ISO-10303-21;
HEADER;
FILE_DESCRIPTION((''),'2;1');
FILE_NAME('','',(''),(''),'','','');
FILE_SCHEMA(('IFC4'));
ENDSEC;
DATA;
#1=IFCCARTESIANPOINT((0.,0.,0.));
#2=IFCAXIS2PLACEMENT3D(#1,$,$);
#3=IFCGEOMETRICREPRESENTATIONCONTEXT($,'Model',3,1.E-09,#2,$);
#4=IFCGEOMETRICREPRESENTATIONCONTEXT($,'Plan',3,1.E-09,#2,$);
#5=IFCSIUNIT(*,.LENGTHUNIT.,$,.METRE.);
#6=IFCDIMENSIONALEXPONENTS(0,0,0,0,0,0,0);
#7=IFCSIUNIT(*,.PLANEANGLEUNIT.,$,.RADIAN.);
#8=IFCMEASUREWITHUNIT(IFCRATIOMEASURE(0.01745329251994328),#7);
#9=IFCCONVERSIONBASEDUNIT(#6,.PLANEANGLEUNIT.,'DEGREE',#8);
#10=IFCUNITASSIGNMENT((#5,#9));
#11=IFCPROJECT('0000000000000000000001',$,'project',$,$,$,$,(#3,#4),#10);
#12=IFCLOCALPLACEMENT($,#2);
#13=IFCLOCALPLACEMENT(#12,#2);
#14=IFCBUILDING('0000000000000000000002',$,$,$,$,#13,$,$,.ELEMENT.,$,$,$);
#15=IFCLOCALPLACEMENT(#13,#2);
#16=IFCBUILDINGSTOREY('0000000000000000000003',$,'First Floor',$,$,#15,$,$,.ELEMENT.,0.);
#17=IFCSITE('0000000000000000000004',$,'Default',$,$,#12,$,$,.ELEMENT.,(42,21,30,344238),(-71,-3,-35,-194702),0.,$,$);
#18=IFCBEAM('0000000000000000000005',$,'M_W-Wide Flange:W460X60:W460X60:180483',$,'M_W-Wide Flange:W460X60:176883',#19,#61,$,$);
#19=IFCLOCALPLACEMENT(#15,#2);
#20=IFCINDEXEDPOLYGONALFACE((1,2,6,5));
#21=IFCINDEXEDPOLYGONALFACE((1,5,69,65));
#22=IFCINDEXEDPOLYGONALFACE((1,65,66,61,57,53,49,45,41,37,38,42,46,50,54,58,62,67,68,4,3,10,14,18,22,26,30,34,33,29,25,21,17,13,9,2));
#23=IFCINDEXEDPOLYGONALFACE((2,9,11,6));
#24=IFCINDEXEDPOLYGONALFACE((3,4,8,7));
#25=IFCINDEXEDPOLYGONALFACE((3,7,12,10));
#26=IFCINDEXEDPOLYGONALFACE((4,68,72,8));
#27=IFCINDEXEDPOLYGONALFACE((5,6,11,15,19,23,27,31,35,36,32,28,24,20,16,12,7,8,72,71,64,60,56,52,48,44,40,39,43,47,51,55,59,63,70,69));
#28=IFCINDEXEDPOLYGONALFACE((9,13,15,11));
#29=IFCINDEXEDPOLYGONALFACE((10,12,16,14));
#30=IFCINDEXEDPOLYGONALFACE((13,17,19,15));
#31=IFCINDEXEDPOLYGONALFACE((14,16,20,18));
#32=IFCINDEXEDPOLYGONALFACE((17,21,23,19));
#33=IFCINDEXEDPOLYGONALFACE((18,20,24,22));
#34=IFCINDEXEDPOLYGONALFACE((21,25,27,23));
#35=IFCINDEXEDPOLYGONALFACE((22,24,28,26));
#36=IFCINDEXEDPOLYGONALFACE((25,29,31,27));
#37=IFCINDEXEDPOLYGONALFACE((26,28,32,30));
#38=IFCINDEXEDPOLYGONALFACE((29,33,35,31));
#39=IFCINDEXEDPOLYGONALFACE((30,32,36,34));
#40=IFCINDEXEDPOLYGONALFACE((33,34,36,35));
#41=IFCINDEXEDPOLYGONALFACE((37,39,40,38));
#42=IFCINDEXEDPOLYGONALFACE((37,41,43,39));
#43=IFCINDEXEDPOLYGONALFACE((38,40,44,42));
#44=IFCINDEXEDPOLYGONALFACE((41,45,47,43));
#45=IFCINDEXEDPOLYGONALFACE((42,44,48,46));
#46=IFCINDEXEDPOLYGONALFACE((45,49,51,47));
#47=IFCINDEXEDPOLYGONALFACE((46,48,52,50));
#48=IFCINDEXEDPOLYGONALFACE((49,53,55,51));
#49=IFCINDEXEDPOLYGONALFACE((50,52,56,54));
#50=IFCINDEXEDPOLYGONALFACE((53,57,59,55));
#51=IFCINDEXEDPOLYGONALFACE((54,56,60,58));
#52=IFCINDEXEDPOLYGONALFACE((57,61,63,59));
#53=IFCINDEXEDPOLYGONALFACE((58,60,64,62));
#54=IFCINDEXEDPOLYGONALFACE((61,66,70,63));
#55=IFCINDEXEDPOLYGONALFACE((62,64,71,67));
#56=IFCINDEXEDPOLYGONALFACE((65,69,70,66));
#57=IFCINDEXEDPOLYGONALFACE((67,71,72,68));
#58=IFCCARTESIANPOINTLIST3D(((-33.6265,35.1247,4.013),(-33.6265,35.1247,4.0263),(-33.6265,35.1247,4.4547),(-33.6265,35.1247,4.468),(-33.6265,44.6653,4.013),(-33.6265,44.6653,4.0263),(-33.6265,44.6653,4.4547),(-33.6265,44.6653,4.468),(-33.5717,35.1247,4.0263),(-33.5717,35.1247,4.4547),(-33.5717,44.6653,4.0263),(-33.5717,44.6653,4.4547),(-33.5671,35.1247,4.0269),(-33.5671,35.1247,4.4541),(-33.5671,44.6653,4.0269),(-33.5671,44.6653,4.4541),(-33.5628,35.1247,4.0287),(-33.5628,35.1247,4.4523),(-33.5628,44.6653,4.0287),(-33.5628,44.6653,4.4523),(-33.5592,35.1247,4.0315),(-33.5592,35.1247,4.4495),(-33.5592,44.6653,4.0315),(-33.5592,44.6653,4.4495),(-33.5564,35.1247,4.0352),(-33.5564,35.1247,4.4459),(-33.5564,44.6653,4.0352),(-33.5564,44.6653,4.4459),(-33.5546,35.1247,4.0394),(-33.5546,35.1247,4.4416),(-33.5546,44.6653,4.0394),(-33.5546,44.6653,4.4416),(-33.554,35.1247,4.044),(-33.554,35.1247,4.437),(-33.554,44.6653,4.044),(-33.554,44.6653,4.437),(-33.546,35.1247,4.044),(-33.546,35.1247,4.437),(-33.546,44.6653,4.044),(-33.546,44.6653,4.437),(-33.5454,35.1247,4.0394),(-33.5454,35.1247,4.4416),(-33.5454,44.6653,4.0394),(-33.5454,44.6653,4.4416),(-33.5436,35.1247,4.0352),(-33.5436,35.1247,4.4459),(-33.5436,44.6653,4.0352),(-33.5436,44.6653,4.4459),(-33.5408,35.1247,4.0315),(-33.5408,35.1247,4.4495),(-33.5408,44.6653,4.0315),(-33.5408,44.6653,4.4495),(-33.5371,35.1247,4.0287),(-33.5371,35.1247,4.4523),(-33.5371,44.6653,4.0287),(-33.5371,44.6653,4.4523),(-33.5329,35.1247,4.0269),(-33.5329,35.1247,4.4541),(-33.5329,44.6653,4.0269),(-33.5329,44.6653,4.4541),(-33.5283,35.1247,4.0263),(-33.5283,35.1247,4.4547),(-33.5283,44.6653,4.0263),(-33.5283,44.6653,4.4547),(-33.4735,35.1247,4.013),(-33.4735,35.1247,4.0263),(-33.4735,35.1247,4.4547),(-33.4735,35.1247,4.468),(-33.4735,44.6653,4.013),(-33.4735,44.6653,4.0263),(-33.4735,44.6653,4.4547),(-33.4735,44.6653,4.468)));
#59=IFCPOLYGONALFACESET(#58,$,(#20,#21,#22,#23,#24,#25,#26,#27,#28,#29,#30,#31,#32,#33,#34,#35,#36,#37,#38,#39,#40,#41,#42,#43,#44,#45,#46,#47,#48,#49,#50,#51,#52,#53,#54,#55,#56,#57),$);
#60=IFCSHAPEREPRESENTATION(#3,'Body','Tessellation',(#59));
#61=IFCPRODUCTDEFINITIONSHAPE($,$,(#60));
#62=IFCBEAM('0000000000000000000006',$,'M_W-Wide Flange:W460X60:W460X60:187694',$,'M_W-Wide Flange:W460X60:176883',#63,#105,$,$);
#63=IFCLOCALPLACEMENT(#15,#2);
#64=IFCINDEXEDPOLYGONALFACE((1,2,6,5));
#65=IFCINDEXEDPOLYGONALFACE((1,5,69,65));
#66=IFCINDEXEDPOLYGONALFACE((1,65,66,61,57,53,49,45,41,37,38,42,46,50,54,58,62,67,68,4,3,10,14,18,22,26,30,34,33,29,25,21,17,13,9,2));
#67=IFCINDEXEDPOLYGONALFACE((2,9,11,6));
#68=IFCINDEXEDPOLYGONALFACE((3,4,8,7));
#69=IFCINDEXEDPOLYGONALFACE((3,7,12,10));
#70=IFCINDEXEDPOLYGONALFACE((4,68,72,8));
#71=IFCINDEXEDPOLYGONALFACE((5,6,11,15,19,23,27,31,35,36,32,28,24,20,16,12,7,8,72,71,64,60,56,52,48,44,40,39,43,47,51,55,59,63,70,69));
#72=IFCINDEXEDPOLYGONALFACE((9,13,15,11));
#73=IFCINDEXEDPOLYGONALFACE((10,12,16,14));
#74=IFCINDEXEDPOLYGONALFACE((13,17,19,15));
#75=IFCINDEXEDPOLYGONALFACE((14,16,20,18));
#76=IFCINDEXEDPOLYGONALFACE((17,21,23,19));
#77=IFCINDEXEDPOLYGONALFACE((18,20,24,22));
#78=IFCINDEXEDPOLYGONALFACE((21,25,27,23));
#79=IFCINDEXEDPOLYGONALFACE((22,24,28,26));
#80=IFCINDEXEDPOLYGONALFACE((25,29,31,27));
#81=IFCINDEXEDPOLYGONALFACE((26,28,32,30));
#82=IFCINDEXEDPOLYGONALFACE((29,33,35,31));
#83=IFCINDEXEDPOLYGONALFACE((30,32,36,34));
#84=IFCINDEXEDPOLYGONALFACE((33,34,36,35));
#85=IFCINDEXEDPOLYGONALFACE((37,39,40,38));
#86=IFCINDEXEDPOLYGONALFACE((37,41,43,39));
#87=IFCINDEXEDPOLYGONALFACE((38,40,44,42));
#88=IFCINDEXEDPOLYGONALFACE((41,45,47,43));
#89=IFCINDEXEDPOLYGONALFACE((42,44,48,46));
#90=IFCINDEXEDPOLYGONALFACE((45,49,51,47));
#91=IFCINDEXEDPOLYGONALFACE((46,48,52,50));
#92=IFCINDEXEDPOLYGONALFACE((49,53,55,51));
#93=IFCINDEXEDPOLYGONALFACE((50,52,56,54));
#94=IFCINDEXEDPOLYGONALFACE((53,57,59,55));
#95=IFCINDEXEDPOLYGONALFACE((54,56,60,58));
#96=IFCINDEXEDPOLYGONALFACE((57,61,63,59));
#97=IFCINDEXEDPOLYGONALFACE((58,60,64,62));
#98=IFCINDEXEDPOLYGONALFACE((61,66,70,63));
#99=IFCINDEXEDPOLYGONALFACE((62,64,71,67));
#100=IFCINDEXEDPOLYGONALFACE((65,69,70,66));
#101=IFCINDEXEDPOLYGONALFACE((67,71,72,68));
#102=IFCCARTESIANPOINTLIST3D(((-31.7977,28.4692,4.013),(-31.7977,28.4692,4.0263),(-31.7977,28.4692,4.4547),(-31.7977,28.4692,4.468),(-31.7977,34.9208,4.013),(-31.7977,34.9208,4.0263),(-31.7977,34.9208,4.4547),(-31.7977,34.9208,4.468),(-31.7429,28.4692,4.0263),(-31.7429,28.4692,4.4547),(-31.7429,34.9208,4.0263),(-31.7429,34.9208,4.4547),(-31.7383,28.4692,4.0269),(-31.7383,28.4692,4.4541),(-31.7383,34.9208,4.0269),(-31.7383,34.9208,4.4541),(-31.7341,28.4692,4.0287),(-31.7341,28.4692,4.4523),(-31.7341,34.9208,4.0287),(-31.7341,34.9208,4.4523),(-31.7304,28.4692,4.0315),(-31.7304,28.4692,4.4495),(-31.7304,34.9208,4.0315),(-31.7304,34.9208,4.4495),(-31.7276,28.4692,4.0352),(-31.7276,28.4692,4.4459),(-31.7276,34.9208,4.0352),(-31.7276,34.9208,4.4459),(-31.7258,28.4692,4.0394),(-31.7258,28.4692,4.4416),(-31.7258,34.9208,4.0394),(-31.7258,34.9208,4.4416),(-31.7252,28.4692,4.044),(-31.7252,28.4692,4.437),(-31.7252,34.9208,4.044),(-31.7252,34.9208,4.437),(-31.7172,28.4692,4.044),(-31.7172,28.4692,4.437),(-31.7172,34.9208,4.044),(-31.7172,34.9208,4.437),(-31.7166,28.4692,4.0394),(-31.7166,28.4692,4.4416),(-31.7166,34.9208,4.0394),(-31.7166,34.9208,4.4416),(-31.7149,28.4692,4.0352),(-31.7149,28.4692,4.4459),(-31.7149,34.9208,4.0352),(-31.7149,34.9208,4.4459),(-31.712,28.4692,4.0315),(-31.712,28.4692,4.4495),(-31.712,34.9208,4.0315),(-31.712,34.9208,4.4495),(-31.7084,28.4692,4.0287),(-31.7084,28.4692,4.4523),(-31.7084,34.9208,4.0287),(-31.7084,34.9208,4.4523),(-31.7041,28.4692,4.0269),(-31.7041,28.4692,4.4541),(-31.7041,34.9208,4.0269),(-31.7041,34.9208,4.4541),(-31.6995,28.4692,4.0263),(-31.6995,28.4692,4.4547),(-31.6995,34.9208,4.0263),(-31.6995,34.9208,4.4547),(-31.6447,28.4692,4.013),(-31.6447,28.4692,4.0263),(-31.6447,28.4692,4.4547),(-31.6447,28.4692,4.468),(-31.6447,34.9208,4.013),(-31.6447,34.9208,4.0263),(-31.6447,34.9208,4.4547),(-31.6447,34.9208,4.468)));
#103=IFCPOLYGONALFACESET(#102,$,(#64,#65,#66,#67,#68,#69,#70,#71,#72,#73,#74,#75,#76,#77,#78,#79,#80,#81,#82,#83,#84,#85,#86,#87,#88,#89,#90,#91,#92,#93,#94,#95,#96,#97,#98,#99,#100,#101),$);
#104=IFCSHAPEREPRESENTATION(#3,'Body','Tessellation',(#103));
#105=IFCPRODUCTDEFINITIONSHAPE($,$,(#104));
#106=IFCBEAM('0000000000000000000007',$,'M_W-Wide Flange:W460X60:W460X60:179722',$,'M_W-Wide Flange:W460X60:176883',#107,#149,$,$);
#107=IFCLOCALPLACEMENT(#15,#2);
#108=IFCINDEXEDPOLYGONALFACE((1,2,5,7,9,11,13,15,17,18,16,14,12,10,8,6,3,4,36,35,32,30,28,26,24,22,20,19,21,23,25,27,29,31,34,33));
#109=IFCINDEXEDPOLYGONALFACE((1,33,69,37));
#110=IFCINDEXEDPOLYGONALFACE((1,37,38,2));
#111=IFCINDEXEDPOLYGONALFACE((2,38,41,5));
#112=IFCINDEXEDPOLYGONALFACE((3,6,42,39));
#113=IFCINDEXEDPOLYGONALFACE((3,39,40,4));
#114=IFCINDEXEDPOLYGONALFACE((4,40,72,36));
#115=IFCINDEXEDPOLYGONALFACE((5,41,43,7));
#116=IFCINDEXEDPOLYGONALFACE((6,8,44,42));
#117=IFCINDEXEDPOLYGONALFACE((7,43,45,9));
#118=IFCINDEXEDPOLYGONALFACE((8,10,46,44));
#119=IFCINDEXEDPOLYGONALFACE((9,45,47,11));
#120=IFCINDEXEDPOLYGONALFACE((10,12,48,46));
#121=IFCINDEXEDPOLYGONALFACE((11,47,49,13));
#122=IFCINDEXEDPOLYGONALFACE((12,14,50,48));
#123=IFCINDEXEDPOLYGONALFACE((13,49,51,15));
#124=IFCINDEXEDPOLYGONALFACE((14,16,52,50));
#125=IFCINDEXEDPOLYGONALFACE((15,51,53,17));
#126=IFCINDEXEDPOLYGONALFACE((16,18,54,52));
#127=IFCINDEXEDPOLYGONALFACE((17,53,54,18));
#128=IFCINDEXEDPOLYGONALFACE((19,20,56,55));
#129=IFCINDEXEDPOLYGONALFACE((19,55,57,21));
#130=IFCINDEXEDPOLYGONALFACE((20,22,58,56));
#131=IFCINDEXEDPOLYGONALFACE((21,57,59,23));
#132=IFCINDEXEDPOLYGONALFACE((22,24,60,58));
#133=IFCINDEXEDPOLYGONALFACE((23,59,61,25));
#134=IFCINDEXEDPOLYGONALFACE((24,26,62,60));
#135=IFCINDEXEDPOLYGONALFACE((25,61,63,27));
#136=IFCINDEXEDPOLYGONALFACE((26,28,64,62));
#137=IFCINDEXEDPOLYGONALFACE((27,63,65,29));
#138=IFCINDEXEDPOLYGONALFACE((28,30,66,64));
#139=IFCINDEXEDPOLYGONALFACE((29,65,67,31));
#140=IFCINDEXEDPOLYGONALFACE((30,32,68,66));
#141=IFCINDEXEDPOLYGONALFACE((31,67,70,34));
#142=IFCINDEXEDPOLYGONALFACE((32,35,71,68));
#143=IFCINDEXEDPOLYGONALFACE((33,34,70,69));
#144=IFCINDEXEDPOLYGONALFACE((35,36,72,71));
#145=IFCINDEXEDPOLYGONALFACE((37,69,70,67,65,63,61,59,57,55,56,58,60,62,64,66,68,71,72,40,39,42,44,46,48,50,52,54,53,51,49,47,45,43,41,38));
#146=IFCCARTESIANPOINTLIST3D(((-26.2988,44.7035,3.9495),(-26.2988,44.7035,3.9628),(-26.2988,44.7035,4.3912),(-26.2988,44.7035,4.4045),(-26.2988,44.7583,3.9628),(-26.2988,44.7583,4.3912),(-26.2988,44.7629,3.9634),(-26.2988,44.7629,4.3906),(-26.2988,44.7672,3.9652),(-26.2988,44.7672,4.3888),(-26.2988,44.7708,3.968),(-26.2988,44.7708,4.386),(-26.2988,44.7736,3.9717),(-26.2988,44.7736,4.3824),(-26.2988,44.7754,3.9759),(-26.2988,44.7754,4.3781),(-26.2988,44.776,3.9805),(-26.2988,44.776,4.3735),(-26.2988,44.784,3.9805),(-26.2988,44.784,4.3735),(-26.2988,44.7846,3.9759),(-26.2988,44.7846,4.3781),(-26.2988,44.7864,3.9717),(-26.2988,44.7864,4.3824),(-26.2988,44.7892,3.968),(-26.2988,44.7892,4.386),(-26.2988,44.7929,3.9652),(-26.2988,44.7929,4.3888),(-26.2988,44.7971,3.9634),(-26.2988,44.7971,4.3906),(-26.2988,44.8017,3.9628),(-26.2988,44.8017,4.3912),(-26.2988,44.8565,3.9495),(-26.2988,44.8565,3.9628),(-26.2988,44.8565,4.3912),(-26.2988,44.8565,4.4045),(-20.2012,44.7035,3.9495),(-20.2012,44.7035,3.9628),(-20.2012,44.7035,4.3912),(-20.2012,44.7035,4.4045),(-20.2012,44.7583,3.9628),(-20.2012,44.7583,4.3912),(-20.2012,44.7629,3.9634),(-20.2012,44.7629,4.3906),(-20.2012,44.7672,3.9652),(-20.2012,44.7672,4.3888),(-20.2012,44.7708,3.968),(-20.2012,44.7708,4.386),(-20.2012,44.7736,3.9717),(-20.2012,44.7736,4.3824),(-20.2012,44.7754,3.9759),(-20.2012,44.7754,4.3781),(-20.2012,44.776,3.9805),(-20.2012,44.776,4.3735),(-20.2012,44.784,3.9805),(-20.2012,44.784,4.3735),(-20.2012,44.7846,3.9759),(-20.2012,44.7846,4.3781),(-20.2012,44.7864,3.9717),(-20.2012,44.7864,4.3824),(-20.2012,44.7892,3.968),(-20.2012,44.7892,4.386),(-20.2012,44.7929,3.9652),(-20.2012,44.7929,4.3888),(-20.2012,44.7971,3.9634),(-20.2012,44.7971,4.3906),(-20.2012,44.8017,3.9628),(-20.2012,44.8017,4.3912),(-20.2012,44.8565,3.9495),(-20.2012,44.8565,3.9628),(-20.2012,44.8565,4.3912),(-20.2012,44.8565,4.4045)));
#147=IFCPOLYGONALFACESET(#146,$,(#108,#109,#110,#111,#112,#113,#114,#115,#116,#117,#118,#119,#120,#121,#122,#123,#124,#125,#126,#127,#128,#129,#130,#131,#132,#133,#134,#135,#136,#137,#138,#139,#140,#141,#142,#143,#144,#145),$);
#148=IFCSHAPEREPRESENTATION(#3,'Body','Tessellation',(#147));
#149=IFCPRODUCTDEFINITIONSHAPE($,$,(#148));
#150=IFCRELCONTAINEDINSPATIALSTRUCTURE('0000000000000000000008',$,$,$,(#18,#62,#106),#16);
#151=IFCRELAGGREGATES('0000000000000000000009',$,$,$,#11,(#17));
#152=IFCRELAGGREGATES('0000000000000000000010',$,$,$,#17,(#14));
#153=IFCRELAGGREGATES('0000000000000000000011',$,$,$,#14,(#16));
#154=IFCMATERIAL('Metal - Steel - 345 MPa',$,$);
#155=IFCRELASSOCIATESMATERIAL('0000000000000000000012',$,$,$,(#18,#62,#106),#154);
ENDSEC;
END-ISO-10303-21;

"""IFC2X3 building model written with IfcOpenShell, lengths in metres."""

from ifc_helpers import new_model, entity, si_unit, converted_unit, frame, frame_2d, origin, place, context, project, spatial, polyline, circle_curve, parameter, trimmed, segment, composite_curve, outline, extrude, material, element, save


model = new_model("IFC2X3")

# Units and contexts
model_context = context("Model", 3, precision=1e-09, world=origin())
plan_context = context("Plan", 3, precision=1e-09, world=origin())
ifc_project = project(units=[si_unit("LENGTHUNIT", "METRE"), converted_unit("PLANEANGLEUNIT", "DEGREE", entity("IfcRatioMeasure", 0.01745329251994328), si_unit("PLANEANGLEUNIT", "RADIAN"), dimensions=[0, 0, 0, 0, 0, 0, 0])], contexts=[model_context, plan_context])

# Site, building, storey
site_placement = place(None, origin())
site = spatial("IfcSite", under=ifc_project, at=site_placement, Name="Default", CompositionType="ELEMENT", RefLatitude=(42, 21, 30, 344238), RefLongitude=(-71, -3, -35, -194702), RefElevation=0.0)
building_placement = place(site_placement, origin())
building = spatial("IfcBuilding", under=site, at=building_placement, CompositionType="ELEMENT")
storey_placement = place(building_placement, origin())
storey = spatial("IfcBuildingStorey", under=building, at=storey_placement, Name="First Floor", CompositionType="ELEMENT", Elevation=0.0)

# Beams
ifc_material = material(Name="Metal - Steel - 345 MPa")
beam_1_placement = place(storey_placement, frame((-33.55, 44.7814, 4.468), z_axis=(0.0, 0.0, 1.0), x_axis=(-1.0, 0.0, 0.0)))
element("IfcBeam", 1, at=beam_1_placement, inside=storey, material=ifc_material, Name="M_W-Wide Flange:W460X60:W460X60:180483", ObjectType="M_W-Wide Flange:W460X60:176883", context=model_context, shape_type="SweptSolid", body=[
    extrude(outline(composite_curve([segment(polyline([(0.2142, -0.0765), (0.2275, -0.0765)]), True, "CONTINUOUS"), segment(polyline([(0.2275, -0.0765), (0.2275, 0.0765)]), True, "CONTINUOUS"), segment(polyline([(0.2275, 0.0765), (0.2142, 0.0765)]), True, "CONTINUOUS"), segment(polyline([(0.2142, 0.0765), (0.2142, 0.0217)]), True, "CONTINUOUS"), segment(trimmed(circle_curve(frame_2d((0.1965, 0.0217), x_axis=(1.0, 0.0)), 0.0177), [parameter(270.0)], [parameter(360.0)], True, "PARAMETER"), False, "CONTINUOUS"), segment(polyline([(0.1965, 0.004), (-0.1965, 0.004)]), True, "CONTINUOUS"), segment(trimmed(circle_curve(frame_2d((-0.1965, 0.0217), x_axis=(0.0, -1.0)), 0.0177), [parameter(270.0)], [parameter(360.0)], True, "PARAMETER"), False, "CONTINUOUS"), segment(polyline([(-0.2142, 0.0217), (-0.2142, 0.0765)]), True, "CONTINUOUS"), segment(polyline([(-0.2142, 0.0765), (-0.2275, 0.0765)]), True, "CONTINUOUS"), segment(polyline([(-0.2275, 0.0765), (-0.2275, -0.0765)]), True, "CONTINUOUS"), segment(polyline([(-0.2275, -0.0765), (-0.2142, -0.0765)]), True, "CONTINUOUS"), segment(polyline([(-0.2142, -0.0765), (-0.2142, -0.0217)]), True, "CONTINUOUS"), segment(trimmed(circle_curve(frame_2d((-0.1965, -0.0217), x_axis=(-1.0, 0.0)), 0.0177), [parameter(270.0)], [parameter(360.0)], True, "PARAMETER"), False, "CONTINUOUS"), segment(polyline([(-0.1965, -0.004), (0.1965, -0.004)]), True, "CONTINUOUS"), segment(trimmed(circle_curve(frame_2d((0.1965, -0.0217), x_axis=(0.0, 1.0)), 0.0177), [parameter(270.0)], [parameter(0.0)], True, "PARAMETER"), False, "CONTINUOUS"), segment(polyline([(0.2142, -0.0217), (0.2142, -0.0765)]), True, "CONTINUOUS")], self_intersect=False)), frame((0.0, 9.6567, -0.2275), z_axis=(0.0, -1.0, 0.0), x_axis=(0.0, 0.0, -1.0)), (0.0, 0.0, 1.0), 9.5406),
])
beam_2_placement = place(storey_placement, frame((-31.7212, 28.5304, 4.468)))
element("IfcBeam", 2, at=beam_2_placement, inside=storey, material=ifc_material, Name="M_W-Wide Flange:W460X60:W460X60:187694", ObjectType="M_W-Wide Flange:W460X60:176883", context=model_context, shape_type="SweptSolid", body=[
    extrude(outline(composite_curve([segment(polyline([(-0.0765, -0.2142), (-0.0765, -0.2275)]), True, "CONTINUOUS"), segment(polyline([(-0.0765, -0.2275), (0.0765, -0.2275)]), True, "CONTINUOUS"), segment(polyline([(0.0765, -0.2275), (0.0765, -0.2142)]), True, "CONTINUOUS"), segment(polyline([(0.0765, -0.2142), (0.0217, -0.2142)]), True, "CONTINUOUS"), segment(trimmed(circle_curve(frame_2d((0.0217, -0.1965), x_axis=(1.0, 0.0)), 0.0177), [parameter(180.0)], [parameter(270.0)], True, "PARAMETER"), False, "CONTINUOUS"), segment(polyline([(0.004, -0.1965), (0.004, 0.1965)]), True, "CONTINUOUS"), segment(trimmed(circle_curve(frame_2d((0.0217, 0.1965), x_axis=(1.0, 0.0)), 0.0177), [parameter(90.0)], [parameter(180.0)], True, "PARAMETER"), False, "CONTINUOUS"), segment(polyline([(0.0217, 0.2142), (0.0765, 0.2142)]), True, "CONTINUOUS"), segment(polyline([(0.0765, 0.2142), (0.0765, 0.2275)]), True, "CONTINUOUS"), segment(polyline([(0.0765, 0.2275), (-0.0765, 0.2275)]), True, "CONTINUOUS"), segment(polyline([(-0.0765, 0.2275), (-0.0765, 0.2142)]), True, "CONTINUOUS"), segment(polyline([(-0.0765, 0.2142), (-0.0217, 0.2142)]), True, "CONTINUOUS"), segment(trimmed(circle_curve(frame_2d((-0.0217, 0.1965), x_axis=(1.0, 0.0)), 0.0177), [parameter(360.0)], [parameter(90.0)], True, "PARAMETER"), False, "CONTINUOUS"), segment(polyline([(-0.004, 0.1965), (-0.004, -0.1965)]), True, "CONTINUOUS"), segment(trimmed(circle_curve(frame_2d((-0.0217, -0.1965), x_axis=(1.0, 0.0)), 0.0177), [parameter(270.0)], [parameter(0.0)], True, "PARAMETER"), False, "CONTINUOUS"), segment(polyline([(-0.0217, -0.2142), (-0.0765, -0.2142)]), True, "CONTINUOUS")], self_intersect=False)), frame((0.0, -0.0612, -0.2275), z_axis=(0.0, -1.0, 0.0), x_axis=(1.0, 0.0, 0.0)), (0.0, 0.0, -1.0), 6.4516),
])
beam_3_placement = place(storey_placement, frame((-26.4421, 44.78, 4.4045), z_axis=(0.0, 0.0, 1.0), x_axis=(0.0, -1.0, 0.0)))
element("IfcBeam", 3, at=beam_3_placement, inside=storey, material=ifc_material, Name="M_W-Wide Flange:W460X60:W460X60:179722", ObjectType="M_W-Wide Flange:W460X60:176883", context=model_context, shape_type="SweptSolid", body=[
    extrude(outline(composite_curve([segment(polyline([(-0.0765, -0.2142), (-0.0765, -0.2275)]), True, "CONTINUOUS"), segment(polyline([(-0.0765, -0.2275), (0.0765, -0.2275)]), True, "CONTINUOUS"), segment(polyline([(0.0765, -0.2275), (0.0765, -0.2142)]), True, "CONTINUOUS"), segment(polyline([(0.0765, -0.2142), (0.0217, -0.2142)]), True, "CONTINUOUS"), segment(trimmed(circle_curve(frame_2d((0.0217, -0.1965), x_axis=(0.0, -1.0)), 0.0177), [parameter(270.0)], [parameter(360.0)], True, "PARAMETER"), False, "CONTINUOUS"), segment(polyline([(0.004, -0.1965), (0.004, 0.1965)]), True, "CONTINUOUS"), segment(trimmed(circle_curve(frame_2d((0.0217, 0.1965), x_axis=(-1.0, 0.0)), 0.0177), [parameter(270.0)], [parameter(360.0)], True, "PARAMETER"), False, "CONTINUOUS"), segment(polyline([(0.0217, 0.2142), (0.0765, 0.2142)]), True, "CONTINUOUS"), segment(polyline([(0.0765, 0.2142), (0.0765, 0.2275)]), True, "CONTINUOUS"), segment(polyline([(0.0765, 0.2275), (-0.0765, 0.2275)]), True, "CONTINUOUS"), segment(polyline([(-0.0765, 0.2275), (-0.0765, 0.2142)]), True, "CONTINUOUS"), segment(polyline([(-0.0765, 0.2142), (-0.0217, 0.2142)]), True, "CONTINUOUS"), segment(trimmed(circle_curve(frame_2d((-0.0217, 0.1965), x_axis=(0.0, 1.0)), 0.0177), [parameter(270.0)], [parameter(360.0)], True, "PARAMETER"), False, "CONTINUOUS"), segment(polyline([(-0.004, 0.1965), (-0.004, -0.1965)]), True, "CONTINUOUS"), segment(trimmed(circle_curve(frame_2d((-0.0217, -0.1965), x_axis=(1.0, 0.0)), 0.0177), [parameter(270.0)], [parameter(0.0)], True, "PARAMETER"), False, "CONTINUOUS"), segment(polyline([(-0.0217, -0.2142), (-0.0765, -0.2142)]), True, "CONTINUOUS")], self_intersect=False)), frame((0.0, 0.1433, -0.2275), z_axis=(0.0, -1.0, 0.0), x_axis=(1.0, 0.0, 0.0)), (0.0, 0.0, -1.0), 6.0976),
])

save(model, "model.ifc")
